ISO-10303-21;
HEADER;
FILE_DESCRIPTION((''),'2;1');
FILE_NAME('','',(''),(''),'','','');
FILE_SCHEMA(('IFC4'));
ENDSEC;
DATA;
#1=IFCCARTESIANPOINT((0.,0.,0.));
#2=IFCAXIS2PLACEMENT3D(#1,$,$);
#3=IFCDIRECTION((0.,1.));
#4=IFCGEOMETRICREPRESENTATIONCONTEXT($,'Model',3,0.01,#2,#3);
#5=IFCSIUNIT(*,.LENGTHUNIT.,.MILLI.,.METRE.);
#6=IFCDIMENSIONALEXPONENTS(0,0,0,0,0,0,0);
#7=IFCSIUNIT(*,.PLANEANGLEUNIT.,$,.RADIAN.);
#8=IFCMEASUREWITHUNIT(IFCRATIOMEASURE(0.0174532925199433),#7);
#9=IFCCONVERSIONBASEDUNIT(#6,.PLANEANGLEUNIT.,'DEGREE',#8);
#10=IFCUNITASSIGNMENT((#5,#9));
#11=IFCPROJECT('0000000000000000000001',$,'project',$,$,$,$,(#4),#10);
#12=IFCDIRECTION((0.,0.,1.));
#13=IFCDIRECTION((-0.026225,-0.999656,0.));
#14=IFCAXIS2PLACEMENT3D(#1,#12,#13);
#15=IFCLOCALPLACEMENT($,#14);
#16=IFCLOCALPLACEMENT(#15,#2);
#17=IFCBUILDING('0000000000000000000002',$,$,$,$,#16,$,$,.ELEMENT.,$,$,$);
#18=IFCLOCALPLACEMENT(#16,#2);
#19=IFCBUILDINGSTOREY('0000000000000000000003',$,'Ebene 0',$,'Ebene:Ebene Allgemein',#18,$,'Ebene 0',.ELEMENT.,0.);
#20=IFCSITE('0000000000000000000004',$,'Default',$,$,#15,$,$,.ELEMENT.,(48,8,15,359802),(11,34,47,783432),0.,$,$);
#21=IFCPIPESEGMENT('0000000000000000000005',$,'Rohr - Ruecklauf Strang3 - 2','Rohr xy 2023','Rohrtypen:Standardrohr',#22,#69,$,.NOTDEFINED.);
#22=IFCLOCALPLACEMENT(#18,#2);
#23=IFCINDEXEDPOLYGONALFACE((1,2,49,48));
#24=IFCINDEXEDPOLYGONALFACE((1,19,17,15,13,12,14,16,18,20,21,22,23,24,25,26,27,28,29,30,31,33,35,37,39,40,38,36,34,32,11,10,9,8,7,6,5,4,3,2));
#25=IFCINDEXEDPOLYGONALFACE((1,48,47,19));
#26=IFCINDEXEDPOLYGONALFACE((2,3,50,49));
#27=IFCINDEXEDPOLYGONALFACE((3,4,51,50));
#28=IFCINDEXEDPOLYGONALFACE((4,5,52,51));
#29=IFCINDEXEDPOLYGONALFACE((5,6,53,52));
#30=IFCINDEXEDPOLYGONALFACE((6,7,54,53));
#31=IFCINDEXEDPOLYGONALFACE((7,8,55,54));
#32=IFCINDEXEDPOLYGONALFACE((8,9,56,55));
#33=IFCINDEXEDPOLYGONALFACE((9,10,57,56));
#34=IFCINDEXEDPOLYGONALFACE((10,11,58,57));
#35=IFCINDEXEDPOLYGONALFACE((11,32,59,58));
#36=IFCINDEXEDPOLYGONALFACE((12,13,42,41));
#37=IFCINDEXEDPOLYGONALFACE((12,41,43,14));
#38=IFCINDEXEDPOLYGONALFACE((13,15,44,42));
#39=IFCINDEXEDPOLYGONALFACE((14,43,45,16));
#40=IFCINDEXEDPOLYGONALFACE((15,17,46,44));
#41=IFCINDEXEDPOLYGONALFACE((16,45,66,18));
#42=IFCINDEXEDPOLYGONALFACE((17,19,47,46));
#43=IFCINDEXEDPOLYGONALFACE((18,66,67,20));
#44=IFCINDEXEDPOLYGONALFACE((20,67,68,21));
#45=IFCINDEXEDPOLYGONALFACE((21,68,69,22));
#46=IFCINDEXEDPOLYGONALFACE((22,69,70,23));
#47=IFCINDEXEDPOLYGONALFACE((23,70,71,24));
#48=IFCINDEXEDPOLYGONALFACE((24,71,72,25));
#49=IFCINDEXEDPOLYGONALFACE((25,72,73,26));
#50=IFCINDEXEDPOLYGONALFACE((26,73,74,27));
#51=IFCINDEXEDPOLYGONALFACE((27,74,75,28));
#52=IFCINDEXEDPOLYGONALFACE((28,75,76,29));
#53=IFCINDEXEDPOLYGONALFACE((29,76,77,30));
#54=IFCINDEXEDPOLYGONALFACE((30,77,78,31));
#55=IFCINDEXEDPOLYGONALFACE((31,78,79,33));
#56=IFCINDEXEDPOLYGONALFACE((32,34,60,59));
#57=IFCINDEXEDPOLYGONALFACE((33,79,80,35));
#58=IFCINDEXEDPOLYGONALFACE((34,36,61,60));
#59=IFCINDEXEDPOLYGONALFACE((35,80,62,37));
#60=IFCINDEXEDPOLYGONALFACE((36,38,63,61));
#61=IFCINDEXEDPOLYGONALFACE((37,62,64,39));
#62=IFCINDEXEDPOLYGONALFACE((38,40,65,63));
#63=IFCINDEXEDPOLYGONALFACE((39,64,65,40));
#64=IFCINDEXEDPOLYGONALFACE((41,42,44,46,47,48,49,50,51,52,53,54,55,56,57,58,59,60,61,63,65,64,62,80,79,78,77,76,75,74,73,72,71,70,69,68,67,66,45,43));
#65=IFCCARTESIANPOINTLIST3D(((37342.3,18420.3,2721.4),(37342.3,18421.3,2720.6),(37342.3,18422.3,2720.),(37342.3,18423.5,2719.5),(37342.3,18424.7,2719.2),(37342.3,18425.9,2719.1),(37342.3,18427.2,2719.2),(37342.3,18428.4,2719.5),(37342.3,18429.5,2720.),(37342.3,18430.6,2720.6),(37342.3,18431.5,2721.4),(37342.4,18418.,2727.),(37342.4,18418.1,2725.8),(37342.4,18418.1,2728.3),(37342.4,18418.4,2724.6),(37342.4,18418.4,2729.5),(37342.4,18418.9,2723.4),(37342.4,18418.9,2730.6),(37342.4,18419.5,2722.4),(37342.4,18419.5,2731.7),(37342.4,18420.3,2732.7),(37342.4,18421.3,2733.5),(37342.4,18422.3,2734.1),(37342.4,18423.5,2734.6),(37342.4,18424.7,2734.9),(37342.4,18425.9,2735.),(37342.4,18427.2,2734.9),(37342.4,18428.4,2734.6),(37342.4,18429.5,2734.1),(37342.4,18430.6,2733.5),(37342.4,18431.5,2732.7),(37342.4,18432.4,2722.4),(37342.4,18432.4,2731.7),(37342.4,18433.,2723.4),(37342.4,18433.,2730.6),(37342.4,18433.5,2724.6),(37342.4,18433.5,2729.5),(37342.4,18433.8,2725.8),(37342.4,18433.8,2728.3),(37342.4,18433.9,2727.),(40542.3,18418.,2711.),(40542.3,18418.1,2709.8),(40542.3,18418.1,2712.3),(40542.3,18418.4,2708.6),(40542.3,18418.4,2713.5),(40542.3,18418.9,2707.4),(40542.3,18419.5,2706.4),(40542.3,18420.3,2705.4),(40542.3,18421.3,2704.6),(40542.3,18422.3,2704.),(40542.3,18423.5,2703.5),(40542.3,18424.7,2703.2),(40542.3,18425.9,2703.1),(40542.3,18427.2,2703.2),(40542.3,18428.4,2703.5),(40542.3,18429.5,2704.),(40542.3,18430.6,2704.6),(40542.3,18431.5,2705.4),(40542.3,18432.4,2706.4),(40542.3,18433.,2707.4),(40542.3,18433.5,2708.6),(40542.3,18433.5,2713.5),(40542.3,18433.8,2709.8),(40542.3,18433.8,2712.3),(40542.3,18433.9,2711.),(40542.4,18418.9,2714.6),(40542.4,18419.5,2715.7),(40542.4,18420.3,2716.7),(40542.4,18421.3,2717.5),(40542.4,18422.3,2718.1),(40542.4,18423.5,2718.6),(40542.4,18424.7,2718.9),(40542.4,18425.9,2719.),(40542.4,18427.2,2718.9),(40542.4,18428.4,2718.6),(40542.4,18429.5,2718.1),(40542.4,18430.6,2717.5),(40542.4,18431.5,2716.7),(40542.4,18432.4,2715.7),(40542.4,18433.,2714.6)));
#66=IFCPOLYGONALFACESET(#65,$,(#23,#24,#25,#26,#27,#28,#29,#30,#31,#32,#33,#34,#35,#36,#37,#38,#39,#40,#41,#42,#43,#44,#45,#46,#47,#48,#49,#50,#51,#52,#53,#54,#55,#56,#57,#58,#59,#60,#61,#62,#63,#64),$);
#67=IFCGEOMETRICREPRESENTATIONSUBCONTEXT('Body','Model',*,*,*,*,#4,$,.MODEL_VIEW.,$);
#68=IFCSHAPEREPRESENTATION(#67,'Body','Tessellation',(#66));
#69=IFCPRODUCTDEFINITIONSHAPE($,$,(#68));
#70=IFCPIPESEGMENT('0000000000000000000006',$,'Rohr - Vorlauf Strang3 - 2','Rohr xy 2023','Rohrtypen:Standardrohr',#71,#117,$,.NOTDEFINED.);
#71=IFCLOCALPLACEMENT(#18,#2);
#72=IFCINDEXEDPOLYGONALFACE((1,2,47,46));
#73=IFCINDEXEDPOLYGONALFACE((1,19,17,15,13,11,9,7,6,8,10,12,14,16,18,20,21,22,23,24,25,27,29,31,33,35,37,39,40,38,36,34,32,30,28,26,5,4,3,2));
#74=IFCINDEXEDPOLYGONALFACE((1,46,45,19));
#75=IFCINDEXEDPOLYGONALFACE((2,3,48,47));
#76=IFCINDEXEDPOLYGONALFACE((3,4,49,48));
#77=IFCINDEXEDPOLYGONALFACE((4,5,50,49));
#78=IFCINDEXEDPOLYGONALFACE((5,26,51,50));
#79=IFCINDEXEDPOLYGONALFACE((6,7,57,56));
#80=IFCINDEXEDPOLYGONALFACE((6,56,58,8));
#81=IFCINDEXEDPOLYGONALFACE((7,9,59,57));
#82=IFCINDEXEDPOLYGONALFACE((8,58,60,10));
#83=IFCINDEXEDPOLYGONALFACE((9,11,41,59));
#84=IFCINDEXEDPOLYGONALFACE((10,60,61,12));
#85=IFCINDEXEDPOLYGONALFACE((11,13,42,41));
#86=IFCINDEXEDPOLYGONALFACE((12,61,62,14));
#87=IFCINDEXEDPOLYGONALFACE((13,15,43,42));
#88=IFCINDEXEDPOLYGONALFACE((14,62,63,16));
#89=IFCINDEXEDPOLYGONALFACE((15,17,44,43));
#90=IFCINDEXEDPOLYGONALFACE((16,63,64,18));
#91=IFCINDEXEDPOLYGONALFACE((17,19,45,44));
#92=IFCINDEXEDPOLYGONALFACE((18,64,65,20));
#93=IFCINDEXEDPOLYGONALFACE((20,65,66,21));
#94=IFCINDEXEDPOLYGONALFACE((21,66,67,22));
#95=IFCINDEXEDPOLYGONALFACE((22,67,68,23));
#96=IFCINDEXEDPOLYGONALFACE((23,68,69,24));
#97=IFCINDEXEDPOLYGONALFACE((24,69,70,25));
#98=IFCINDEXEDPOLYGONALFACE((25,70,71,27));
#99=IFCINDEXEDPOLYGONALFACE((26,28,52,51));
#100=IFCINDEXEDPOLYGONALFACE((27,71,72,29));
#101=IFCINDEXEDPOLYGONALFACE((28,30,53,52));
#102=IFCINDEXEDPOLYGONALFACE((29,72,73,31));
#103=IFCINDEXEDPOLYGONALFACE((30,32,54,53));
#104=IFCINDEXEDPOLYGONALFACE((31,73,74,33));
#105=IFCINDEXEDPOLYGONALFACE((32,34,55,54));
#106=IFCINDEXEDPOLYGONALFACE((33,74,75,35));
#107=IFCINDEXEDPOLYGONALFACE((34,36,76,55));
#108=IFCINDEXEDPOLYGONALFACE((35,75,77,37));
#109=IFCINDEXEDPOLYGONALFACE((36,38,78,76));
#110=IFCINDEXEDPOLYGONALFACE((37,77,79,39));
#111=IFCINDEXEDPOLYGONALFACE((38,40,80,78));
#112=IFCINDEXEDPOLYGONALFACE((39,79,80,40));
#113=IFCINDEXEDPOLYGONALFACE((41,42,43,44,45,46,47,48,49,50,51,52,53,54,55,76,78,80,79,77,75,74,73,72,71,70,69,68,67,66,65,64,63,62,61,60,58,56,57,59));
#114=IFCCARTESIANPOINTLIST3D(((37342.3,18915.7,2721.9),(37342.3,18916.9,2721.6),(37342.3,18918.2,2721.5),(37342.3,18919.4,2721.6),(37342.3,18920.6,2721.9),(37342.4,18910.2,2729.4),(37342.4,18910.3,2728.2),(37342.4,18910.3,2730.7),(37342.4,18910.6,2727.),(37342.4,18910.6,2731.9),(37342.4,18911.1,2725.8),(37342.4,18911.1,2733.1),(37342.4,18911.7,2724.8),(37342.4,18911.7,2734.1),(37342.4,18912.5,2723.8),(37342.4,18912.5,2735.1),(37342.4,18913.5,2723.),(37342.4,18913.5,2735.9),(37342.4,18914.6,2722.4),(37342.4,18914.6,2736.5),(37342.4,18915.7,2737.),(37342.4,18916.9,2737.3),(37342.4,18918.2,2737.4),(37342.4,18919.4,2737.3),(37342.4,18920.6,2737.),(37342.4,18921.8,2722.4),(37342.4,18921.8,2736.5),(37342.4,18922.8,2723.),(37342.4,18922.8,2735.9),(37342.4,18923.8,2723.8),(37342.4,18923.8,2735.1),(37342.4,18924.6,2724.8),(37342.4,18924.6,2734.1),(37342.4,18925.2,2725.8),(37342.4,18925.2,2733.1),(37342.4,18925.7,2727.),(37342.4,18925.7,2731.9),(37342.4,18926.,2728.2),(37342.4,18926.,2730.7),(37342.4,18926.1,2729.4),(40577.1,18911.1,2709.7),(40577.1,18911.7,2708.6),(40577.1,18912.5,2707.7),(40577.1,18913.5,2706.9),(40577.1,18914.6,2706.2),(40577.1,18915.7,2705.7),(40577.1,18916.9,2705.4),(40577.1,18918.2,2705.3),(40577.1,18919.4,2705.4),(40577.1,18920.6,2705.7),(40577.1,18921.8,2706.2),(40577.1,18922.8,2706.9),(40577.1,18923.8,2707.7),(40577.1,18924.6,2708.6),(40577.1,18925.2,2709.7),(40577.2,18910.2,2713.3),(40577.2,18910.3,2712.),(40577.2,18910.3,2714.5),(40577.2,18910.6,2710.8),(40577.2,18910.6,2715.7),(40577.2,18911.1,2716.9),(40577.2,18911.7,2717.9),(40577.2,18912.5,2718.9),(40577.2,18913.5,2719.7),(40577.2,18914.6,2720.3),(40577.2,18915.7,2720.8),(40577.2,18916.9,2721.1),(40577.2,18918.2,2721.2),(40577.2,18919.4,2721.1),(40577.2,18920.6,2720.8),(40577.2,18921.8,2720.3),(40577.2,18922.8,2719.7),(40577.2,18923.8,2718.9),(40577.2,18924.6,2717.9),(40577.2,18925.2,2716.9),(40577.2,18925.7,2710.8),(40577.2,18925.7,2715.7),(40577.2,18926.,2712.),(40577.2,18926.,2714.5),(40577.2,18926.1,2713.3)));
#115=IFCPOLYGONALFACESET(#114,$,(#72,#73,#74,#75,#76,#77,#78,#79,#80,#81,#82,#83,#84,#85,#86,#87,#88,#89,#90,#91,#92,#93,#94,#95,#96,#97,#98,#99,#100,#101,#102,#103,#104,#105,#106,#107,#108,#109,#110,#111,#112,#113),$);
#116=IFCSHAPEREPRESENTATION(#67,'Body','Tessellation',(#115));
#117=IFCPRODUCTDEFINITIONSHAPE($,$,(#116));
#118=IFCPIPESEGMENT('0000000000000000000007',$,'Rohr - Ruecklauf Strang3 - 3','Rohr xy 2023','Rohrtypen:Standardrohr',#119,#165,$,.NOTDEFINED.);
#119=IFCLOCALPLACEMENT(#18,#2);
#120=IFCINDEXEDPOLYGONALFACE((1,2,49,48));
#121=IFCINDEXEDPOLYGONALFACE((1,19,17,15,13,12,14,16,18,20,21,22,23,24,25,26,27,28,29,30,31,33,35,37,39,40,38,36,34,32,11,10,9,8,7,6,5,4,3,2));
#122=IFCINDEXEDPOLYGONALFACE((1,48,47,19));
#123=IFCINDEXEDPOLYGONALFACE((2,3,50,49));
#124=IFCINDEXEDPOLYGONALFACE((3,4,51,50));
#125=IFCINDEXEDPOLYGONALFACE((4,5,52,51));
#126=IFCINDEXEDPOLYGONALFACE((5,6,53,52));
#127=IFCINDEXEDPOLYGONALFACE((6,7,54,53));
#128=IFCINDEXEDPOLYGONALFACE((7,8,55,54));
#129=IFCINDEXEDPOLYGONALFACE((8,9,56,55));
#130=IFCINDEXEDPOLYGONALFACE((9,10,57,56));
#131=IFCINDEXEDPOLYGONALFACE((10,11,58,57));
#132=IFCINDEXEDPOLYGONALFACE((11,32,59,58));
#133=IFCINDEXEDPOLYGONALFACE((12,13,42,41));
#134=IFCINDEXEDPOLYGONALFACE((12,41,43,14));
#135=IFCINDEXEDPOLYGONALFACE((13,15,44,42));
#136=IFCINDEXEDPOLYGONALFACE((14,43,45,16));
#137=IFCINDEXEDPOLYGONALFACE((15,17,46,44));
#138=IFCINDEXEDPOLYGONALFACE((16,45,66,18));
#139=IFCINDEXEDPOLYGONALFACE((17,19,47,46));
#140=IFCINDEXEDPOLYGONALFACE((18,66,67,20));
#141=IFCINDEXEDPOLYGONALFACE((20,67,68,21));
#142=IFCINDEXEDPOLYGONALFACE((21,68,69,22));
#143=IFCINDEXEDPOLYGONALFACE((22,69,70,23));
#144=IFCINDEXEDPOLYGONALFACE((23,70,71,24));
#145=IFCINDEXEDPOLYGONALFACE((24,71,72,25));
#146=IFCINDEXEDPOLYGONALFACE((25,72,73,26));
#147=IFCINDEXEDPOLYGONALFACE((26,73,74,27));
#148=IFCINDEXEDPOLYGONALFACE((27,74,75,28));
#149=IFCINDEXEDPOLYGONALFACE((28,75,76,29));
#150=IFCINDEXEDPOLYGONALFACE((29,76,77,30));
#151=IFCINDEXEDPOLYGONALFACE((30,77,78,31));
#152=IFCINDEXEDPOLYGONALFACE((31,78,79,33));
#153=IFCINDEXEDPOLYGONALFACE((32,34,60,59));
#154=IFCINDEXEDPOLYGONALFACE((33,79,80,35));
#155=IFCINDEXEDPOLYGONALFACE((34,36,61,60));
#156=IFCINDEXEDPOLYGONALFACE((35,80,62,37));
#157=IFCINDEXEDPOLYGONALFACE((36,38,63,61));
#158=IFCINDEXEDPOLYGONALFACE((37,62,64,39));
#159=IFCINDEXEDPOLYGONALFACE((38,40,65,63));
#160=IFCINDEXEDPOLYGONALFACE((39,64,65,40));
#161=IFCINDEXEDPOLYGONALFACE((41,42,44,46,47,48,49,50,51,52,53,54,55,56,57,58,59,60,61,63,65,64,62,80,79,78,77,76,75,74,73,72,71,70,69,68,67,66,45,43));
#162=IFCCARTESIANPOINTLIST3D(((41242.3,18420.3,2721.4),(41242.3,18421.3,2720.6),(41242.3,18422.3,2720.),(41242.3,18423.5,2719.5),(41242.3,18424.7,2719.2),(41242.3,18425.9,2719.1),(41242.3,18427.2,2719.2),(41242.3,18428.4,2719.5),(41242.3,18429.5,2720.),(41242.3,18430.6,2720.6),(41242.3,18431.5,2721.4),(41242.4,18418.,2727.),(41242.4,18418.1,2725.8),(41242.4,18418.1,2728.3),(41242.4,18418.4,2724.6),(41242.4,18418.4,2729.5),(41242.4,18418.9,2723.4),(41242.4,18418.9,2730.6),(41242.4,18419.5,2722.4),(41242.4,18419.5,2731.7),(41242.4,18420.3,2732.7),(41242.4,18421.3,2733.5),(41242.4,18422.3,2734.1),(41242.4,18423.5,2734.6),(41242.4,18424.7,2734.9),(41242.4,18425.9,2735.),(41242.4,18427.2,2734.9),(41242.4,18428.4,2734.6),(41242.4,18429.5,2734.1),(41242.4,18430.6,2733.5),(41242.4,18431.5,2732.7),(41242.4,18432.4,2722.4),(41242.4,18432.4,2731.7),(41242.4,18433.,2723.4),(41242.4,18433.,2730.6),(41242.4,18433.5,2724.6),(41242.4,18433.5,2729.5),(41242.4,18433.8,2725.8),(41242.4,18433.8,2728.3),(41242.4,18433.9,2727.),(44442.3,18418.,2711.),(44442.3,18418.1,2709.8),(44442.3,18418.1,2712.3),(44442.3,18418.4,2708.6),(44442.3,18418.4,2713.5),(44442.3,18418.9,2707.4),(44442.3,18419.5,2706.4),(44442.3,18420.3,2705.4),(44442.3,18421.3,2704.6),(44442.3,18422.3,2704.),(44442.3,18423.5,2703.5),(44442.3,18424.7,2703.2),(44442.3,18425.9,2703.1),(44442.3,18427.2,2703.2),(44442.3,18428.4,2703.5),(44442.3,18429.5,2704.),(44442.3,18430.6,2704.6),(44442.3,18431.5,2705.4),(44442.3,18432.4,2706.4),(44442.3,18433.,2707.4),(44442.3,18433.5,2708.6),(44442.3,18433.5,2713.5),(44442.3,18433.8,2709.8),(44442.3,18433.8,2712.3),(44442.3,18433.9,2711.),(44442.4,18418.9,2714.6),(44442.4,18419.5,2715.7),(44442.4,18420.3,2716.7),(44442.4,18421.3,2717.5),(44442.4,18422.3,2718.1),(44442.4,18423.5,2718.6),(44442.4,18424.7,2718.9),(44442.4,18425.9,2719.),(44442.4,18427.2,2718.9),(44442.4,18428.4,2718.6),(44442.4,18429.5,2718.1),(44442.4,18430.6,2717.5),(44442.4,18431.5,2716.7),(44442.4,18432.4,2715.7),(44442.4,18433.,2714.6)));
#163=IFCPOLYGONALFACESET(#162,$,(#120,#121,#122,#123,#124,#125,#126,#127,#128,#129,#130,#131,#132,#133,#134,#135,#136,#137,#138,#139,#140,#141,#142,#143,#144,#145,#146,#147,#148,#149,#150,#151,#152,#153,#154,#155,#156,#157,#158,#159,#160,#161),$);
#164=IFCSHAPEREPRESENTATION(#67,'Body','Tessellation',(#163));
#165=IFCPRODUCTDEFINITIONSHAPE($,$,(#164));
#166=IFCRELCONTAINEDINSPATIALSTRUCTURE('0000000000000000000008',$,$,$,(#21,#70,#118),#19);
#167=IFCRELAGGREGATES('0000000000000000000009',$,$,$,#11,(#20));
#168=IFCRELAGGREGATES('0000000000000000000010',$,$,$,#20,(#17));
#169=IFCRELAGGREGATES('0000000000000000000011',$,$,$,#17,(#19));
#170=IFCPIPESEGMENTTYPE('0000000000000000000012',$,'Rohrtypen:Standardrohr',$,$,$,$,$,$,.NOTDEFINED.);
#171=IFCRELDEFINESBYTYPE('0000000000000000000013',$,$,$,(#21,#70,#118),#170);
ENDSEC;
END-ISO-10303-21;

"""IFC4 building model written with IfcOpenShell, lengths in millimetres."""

from ifc_helpers import new_model, entity, si_unit, converted_unit, direction, frame, origin, place, context, subcontext, project, spatial, indexed_curve, outline, extrude, type_object, element, save


model = new_model("IFC4")

# Units and contexts
model_context = context("Model", 3, precision=0.01, world=origin(), true_north=direction((0.0, 1.0)))
body_context = subcontext(model_context, "Body", "Model", "MODEL_VIEW")
ifc_project = project(units=[si_unit("LENGTHUNIT", "METRE", prefix="MILLI"), converted_unit("PLANEANGLEUNIT", "DEGREE", entity("IfcRatioMeasure", 0.0174532925199433), si_unit("PLANEANGLEUNIT", "RADIAN"), dimensions=[0, 0, 0, 0, 0, 0, 0])], contexts=[model_context])

# Site, building, storey
site_placement = place(None, frame((0.0, 0.0, 0.0), z_axis=(0.0, 0.0, 1.0), x_axis=(-0.026225, -0.999656, 0.0)))
site = spatial("IfcSite", under=ifc_project, at=site_placement, Name="Default", CompositionType="ELEMENT", RefLatitude=(48, 8, 15, 359802), RefLongitude=(11, 34, 47, 783432), RefElevation=0.0)
building_placement = place(site_placement, origin())
building = spatial("IfcBuilding", under=site, at=building_placement, CompositionType="ELEMENT")
storey_placement = place(building_placement, origin())
storey = spatial("IfcBuildingStorey", under=building, at=storey_placement, Name="Ebene 0", ObjectType="Ebene:Ebene Allgemein", LongName="Ebene 0", CompositionType="ELEMENT", Elevation=0.0)

# Pipe segments
pipe_segment_type = type_object("IfcPipeSegmentType", Name="Rohrtypen:Standardrohr", PredefinedType="NOTDEFINED")
pipe_segment_1_placement = place(storey_placement, origin())
element("IfcPipeSegment", 1, at=pipe_segment_1_placement, inside=storey, type_object=pipe_segment_type, Name="Rohr - Ruecklauf Strang3 - 2", Description="Rohr xy 2023", ObjectType="Rohrtypen:Standardrohr", PredefinedType="NOTDEFINED", context=body_context, shape_type="SweptSolid", body=[
    extrude(outline(indexed_curve([(7.9, 0.0), (7.8, 1.2), (7.6, 2.5), (7.1, 3.6), (6.4, 4.7), (5.6, 5.6), (4.7, 6.4), (3.6, 7.1), (2.5, 7.6), (1.2, 7.8), (0.0, 7.9), (-1.2, 7.8), (-2.5, 7.6), (-3.6, 7.1), (-4.7, 6.4), (-5.6, 5.6), (-6.4, 4.7), (-7.1, 3.6), (-7.6, 2.5), (-7.8, 1.2), (-7.9, 0.0), (-7.8, -1.2), (-7.6, -2.5), (-7.1, -3.6), (-6.4, -4.7), (-5.6, -5.6), (-4.7, -6.4), (-3.6, -7.1), (-2.5, -7.6), (-1.2, -7.8), (0.0, -7.9), (1.2, -7.8), (2.5, -7.6), (3.6, -7.1), (4.7, -6.4), (5.6, -5.6), (6.4, -4.7), (7.1, -3.6), (7.6, -2.5), (7.8, -1.2), (7.9, 0.0)], self_intersect=False)), frame((40542.3, 18425.9, 2711.0), z_axis=(-0.999988, 0.0, 0.005), x_axis=(0.0, 1.0, 0.0)), (0.0, 0.0, 1.0), 3200.0),
])
pipe_segment_2_placement = place(storey_placement, origin())
element("IfcPipeSegment", 2, at=pipe_segment_2_placement, inside=storey, type_object=pipe_segment_type, Name="Rohr - Vorlauf Strang3 - 2", Description="Rohr xy 2023", ObjectType="Rohrtypen:Standardrohr", PredefinedType="NOTDEFINED", context=body_context, shape_type="SweptSolid", body=[
    extrude(outline(indexed_curve([(7.9, 0.0), (7.8, 1.2), (7.6, 2.5), (7.1, 3.6), (6.4, 4.7), (5.6, 5.6), (4.7, 6.4), (3.6, 7.1), (2.5, 7.6), (1.2, 7.8), (0.0, 7.9), (-1.2, 7.8), (-2.5, 7.6), (-3.6, 7.1), (-4.7, 6.4), (-5.6, 5.6), (-6.4, 4.7), (-7.1, 3.6), (-7.6, 2.5), (-7.8, 1.2), (-7.9, 0.0), (-7.8, -1.2), (-7.6, -2.5), (-7.1, -3.6), (-6.4, -4.7), (-5.6, -5.6), (-4.7, -6.4), (-3.6, -7.1), (-2.5, -7.6), (-1.2, -7.8), (0.0, -7.9), (1.2, -7.8), (2.5, -7.6), (3.6, -7.1), (4.7, -6.4), (5.6, -5.6), (6.4, -4.7), (7.1, -3.6), (7.6, -2.5), (7.8, -1.2), (7.9, 0.0)], self_intersect=False)), frame((40577.2, 18918.2, 2713.3), z_axis=(-0.999988, 0.0, 0.005), x_axis=(0.0, 1.0, 0.0)), (0.0, 0.0, 1.0), 3234.8),
])
pipe_segment_3_placement = place(storey_placement, origin())
element("IfcPipeSegment", 3, at=pipe_segment_3_placement, inside=storey, type_object=pipe_segment_type, Name="Rohr - Ruecklauf Strang3 - 3", Description="Rohr xy 2023", ObjectType="Rohrtypen:Standardrohr", PredefinedType="NOTDEFINED", context=body_context, shape_type="SweptSolid", body=[
    extrude(outline(indexed_curve([(7.9, 0.0), (7.8, 1.2), (7.6, 2.5), (7.1, 3.6), (6.4, 4.7), (5.6, 5.6), (4.7, 6.4), (3.6, 7.1), (2.5, 7.6), (1.2, 7.8), (0.0, 7.9), (-1.2, 7.8), (-2.5, 7.6), (-3.6, 7.1), (-4.7, 6.4), (-5.6, 5.6), (-6.4, 4.7), (-7.1, 3.6), (-7.6, 2.5), (-7.8, 1.2), (-7.9, 0.0), (-7.8, -1.2), (-7.6, -2.5), (-7.1, -3.6), (-6.4, -4.7), (-5.6, -5.6), (-4.7, -6.4), (-3.6, -7.1), (-2.5, -7.6), (-1.2, -7.8), (0.0, -7.9), (1.2, -7.8), (2.5, -7.6), (3.6, -7.1), (4.7, -6.4), (5.6, -5.6), (6.4, -4.7), (7.1, -3.6), (7.6, -2.5), (7.8, -1.2), (7.9, 0.0)], self_intersect=False)), frame((44442.3, 18425.9, 2711.0), z_axis=(-0.999988, 0.0, 0.005), x_axis=(0.0, 1.0, 0.0)), (0.0, 0.0, 1.0), 3200.0),
])

save(model, "model.ifc")
